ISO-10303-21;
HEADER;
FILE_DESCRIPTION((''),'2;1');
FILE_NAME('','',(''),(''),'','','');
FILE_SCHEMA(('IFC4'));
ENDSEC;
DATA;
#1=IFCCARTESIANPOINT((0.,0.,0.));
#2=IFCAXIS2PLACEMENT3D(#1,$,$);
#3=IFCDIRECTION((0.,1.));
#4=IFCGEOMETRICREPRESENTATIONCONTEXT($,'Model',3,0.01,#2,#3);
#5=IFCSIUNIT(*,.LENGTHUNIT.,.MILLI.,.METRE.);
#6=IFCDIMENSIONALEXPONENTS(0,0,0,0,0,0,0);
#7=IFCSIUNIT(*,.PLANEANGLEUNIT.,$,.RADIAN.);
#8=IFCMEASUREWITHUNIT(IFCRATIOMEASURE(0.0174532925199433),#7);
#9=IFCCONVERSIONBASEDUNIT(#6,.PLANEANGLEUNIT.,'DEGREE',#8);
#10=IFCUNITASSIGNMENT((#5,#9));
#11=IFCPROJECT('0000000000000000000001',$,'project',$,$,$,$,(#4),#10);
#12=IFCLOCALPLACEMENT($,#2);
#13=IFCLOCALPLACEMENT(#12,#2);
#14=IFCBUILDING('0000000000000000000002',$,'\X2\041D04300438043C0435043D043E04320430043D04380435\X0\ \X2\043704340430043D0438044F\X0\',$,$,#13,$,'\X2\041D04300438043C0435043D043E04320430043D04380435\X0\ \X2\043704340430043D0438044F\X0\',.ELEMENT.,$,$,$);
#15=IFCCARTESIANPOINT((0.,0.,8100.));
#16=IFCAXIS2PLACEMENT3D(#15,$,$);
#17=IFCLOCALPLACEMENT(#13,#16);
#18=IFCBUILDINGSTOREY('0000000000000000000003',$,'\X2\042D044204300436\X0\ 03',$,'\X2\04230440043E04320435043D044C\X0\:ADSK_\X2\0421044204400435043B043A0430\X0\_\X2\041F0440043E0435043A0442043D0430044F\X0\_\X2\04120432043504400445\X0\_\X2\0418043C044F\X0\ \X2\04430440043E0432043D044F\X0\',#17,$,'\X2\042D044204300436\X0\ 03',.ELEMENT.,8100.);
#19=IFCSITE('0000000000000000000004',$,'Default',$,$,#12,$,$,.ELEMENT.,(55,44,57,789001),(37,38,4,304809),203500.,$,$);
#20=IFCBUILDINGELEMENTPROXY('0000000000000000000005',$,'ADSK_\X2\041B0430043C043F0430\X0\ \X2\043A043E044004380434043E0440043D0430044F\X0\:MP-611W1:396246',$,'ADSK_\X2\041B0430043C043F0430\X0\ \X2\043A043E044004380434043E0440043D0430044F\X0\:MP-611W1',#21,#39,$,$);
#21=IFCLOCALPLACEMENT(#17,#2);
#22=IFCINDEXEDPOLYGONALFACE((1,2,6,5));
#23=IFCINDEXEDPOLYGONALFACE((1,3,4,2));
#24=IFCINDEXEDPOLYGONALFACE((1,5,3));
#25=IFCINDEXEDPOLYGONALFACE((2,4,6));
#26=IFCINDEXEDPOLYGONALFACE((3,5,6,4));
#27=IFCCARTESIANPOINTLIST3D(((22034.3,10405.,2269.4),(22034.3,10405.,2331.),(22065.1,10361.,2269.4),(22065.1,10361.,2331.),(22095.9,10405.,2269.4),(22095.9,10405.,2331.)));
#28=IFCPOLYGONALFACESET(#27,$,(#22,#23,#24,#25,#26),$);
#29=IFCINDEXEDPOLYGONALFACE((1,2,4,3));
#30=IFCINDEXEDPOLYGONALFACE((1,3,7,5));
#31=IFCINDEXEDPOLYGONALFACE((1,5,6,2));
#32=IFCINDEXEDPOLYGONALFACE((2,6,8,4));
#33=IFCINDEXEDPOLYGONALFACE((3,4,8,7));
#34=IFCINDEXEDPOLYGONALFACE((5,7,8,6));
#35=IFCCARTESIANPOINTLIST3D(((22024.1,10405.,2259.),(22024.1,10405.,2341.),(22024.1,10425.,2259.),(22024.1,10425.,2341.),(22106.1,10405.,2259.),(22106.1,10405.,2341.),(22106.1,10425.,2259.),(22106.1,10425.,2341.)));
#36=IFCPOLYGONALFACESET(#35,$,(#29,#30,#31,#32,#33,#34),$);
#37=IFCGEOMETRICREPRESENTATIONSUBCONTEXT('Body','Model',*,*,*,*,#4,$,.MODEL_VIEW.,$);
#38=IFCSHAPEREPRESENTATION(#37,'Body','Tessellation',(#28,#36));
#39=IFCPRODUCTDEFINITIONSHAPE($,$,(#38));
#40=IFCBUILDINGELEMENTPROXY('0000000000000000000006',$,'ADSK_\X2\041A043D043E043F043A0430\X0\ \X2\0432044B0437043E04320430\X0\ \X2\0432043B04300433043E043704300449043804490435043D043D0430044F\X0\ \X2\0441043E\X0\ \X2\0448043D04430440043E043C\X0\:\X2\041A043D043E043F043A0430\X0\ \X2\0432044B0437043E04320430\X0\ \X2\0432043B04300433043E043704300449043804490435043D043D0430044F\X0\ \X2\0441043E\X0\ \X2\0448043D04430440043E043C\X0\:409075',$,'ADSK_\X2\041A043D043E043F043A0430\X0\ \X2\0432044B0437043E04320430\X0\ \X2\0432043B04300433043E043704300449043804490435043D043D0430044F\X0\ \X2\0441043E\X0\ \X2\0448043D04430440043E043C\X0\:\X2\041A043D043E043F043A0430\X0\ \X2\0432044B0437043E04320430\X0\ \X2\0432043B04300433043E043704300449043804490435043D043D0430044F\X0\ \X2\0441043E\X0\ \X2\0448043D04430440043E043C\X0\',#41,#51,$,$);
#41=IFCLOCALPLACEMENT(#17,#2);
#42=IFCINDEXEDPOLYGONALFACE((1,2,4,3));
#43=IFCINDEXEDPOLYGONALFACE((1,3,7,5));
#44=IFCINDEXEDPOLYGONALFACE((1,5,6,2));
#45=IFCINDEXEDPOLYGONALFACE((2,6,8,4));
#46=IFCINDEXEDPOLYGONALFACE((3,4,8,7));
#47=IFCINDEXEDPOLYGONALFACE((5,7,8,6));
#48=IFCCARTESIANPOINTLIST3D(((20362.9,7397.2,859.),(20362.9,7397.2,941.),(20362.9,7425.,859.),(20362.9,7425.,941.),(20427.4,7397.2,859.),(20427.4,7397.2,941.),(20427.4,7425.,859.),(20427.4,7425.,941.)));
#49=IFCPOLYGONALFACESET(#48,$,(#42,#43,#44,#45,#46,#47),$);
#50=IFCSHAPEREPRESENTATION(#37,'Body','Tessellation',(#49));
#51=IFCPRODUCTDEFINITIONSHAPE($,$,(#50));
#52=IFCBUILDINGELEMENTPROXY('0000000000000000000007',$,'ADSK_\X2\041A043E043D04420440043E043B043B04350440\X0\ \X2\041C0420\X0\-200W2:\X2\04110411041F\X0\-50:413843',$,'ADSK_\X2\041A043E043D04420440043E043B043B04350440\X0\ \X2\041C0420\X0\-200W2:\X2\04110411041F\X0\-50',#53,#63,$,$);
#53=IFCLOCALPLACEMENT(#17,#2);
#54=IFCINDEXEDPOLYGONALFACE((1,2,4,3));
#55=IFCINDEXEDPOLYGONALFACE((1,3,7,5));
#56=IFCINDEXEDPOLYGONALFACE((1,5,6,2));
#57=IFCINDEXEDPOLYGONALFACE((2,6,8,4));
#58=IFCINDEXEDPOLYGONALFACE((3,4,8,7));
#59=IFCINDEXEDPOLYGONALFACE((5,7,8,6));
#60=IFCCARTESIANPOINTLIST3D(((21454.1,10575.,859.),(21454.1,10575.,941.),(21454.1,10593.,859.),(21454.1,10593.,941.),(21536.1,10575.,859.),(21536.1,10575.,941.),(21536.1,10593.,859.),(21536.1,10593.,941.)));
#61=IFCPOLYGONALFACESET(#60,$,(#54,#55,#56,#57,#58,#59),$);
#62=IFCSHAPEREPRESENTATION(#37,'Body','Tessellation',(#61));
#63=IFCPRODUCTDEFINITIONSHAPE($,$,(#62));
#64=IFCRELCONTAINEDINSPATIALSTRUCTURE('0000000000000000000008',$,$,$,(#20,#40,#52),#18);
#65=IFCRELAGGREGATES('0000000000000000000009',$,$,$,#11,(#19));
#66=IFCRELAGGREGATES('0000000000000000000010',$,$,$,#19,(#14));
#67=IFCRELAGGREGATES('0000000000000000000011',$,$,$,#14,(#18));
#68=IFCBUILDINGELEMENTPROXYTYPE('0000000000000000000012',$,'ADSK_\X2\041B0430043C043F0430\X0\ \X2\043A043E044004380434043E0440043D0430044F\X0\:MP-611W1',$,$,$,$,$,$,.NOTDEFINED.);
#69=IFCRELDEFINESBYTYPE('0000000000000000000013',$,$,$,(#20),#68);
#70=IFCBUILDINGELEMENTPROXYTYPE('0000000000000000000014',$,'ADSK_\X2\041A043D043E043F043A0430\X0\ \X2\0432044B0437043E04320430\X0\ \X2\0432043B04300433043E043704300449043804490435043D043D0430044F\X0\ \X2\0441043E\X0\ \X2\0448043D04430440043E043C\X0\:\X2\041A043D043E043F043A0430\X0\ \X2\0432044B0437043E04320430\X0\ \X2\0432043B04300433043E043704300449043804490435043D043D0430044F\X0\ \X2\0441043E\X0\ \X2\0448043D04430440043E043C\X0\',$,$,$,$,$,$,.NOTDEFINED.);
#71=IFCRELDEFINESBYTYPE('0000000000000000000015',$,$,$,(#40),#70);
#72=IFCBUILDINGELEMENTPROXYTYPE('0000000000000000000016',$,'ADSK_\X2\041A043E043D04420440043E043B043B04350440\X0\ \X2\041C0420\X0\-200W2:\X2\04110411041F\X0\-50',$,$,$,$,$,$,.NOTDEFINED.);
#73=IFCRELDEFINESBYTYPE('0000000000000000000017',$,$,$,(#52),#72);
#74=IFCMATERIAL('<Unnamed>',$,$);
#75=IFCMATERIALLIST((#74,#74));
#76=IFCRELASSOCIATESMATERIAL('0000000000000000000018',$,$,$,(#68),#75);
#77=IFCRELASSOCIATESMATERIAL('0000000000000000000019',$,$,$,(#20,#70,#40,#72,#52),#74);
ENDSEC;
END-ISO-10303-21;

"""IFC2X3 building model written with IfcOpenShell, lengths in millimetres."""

from ifc_helpers import new_model, entity, si_unit, converted_unit, direction, frame, origin, origin_2d_with_axis, place, context, subcontext, project, spatial, polyline, rectangle, outline, extrude, source, transform, mapped, material, material_list, type_object, type_shapes, element, save


model = new_model("IFC2X3")

# Units and contexts
model_context = context("Model", 3, precision=0.01, world=origin(), true_north=direction((0.0, 1.0)))
body_context = subcontext(model_context, "Body", "Model", "MODEL_VIEW")
ifc_project = project(units=[si_unit("LENGTHUNIT", "METRE", prefix="MILLI"), converted_unit("PLANEANGLEUNIT", "DEGREE", entity("IfcRatioMeasure", 0.0174532925199433), si_unit("PLANEANGLEUNIT", "RADIAN"), dimensions=[0, 0, 0, 0, 0, 0, 0])], contexts=[model_context])

# Site, building, storey
site_placement = place(None, origin())
site = spatial("IfcSite", under=ifc_project, at=site_placement, Name="Default", CompositionType="ELEMENT", RefLatitude=(55, 44, 57, 789001), RefLongitude=(37, 38, 4, 304809), RefElevation=203500.0)
building_placement = place(site_placement, origin())
building = spatial("IfcBuilding", under=site, at=building_placement, Name="Наименование здания", LongName="Наименование здания", CompositionType="ELEMENT")
storey_placement = place(building_placement, frame((0.0, 0.0, 8100.0)))
storey = spatial("IfcBuildingStorey", under=building, at=storey_placement, Name="Этаж 03", ObjectType="Уровень:ADSK_Стрелка_Проектная_Вверх_Имя уровня", LongName="Этаж 03", CompositionType="ELEMENT", Elevation=8100.0)

# Building element proxies
ifc_material_1 = material(Name="<Unnamed>")
ifc_material_list_1 = material_list([ifc_material_1, ifc_material_1])
building_element_proxy_type_1 = type_object("IfcBuildingElementProxyType", Name="ADSK_Лампа коридорная:MP-611W1", PredefinedType="NOTDEFINED", material=ifc_material_list_1)
shared_shape_1 = source(origin(), body_context, "Body", "SweptSolid", [
    extrude(outline(polyline([(-30.8, -14.7), (30.8, -14.7), (0.0, 29.3), (-30.8, -14.7)])), frame((0.0, -2.7, -30.6), z_axis=(0.0, 0.0, 1.0), x_axis=(-1.0, 0.0, 0.0)), (0.0, 0.0, 1.0), 61.6),
    extrude(rectangle(XDim=82.0, YDim=20.0, at=origin_2d_with_axis()), frame((0.0, 22.0, -41.0), z_axis=(0.0, 0.0, 1.0), x_axis=(-1.0, 0.0, 0.0)), (0.0, 0.0, 1.0), 82.0),
])
type_shapes(building_element_proxy_type_1, [shared_shape_1])
proxy_1_placement = place(storey_placement, frame((22065.1, 10393.0, 2300.0)))
element("IfcBuildingElementProxy", 1, at=proxy_1_placement, inside=storey, type_object=building_element_proxy_type_1, material=ifc_material_1, Name="ADSK_Лампа коридорная:MP-611W1:396246", ObjectType="ADSK_Лампа коридорная:MP-611W1", context=body_context, shape_type="MappedRepresentation", body=[
    mapped(shared_shape_1, transform((0.0, 0.0, 0.0), scale=1.0)),
])
building_element_proxy_type_2 = type_object("IfcBuildingElementProxyType", Name="ADSK_Кнопка вызова влагозащищенная со шнуром:Кнопка вызова влагозащищенная со шнуром", PredefinedType="NOTDEFINED", material=ifc_material_1)
shared_shape_2 = source(origin(), body_context, "Body", "SweptSolid", [
    extrude(rectangle(XDim=64.5, YDim=27.8, at=origin_2d_with_axis()), frame((32.2, 13.9, 0.0), z_axis=(0.0, 0.0, 1.0), x_axis=(-1.0, 0.0, 0.0)), (0.0, 0.0, 1.0), 82.0),
])
type_shapes(building_element_proxy_type_2, [shared_shape_2])
proxy_2_placement = place(storey_placement, frame((20362.9, 7397.2, 859.0)))
element("IfcBuildingElementProxy", 2, at=proxy_2_placement, inside=storey, type_object=building_element_proxy_type_2, material=ifc_material_1, Name="ADSK_Кнопка вызова влагозащищенная со шнуром:Кнопка вызова влагозащищенная со шнуром:409075", ObjectType="ADSK_Кнопка вызова влагозащищенная со шнуром:Кнопка вызова влагозащищенная со шнуром", context=body_context, shape_type="MappedRepresentation", body=[
    mapped(shared_shape_2, transform((0.0, 0.0, 0.0), scale=1.0)),
])
building_element_proxy_type_3 = type_object("IfcBuildingElementProxyType", Name="ADSK_Контроллер МР-200W2:ББП-50", PredefinedType="NOTDEFINED", material=ifc_material_1)
shared_shape_3 = source(origin(), body_context, "Body", "SweptSolid", [
    extrude(rectangle(XDim=82.0, YDim=18.0, at=origin_2d_with_axis()), frame((41.0, 9.0, 0.0), z_axis=(0.0, 0.0, 1.0), x_axis=(-1.0, 0.0, 0.0)), (0.0, 0.0, 1.0), 82.0),
])
type_shapes(building_element_proxy_type_3, [shared_shape_3])
proxy_3_placement = place(storey_placement, frame((21536.1, 10593.0, 859.0), z_axis=(0.0, 0.0, 1.0), x_axis=(-1.0, 0.0, 0.0)))
element("IfcBuildingElementProxy", 3, at=proxy_3_placement, inside=storey, type_object=building_element_proxy_type_3, material=ifc_material_1, Name="ADSK_Контроллер МР-200W2:ББП-50:413843", ObjectType="ADSK_Контроллер МР-200W2:ББП-50", context=body_context, shape_type="MappedRepresentation", body=[
    mapped(shared_shape_3, transform((0.0, 0.0, 0.0), scale=1.0)),
])

save(model, "model.ifc")
